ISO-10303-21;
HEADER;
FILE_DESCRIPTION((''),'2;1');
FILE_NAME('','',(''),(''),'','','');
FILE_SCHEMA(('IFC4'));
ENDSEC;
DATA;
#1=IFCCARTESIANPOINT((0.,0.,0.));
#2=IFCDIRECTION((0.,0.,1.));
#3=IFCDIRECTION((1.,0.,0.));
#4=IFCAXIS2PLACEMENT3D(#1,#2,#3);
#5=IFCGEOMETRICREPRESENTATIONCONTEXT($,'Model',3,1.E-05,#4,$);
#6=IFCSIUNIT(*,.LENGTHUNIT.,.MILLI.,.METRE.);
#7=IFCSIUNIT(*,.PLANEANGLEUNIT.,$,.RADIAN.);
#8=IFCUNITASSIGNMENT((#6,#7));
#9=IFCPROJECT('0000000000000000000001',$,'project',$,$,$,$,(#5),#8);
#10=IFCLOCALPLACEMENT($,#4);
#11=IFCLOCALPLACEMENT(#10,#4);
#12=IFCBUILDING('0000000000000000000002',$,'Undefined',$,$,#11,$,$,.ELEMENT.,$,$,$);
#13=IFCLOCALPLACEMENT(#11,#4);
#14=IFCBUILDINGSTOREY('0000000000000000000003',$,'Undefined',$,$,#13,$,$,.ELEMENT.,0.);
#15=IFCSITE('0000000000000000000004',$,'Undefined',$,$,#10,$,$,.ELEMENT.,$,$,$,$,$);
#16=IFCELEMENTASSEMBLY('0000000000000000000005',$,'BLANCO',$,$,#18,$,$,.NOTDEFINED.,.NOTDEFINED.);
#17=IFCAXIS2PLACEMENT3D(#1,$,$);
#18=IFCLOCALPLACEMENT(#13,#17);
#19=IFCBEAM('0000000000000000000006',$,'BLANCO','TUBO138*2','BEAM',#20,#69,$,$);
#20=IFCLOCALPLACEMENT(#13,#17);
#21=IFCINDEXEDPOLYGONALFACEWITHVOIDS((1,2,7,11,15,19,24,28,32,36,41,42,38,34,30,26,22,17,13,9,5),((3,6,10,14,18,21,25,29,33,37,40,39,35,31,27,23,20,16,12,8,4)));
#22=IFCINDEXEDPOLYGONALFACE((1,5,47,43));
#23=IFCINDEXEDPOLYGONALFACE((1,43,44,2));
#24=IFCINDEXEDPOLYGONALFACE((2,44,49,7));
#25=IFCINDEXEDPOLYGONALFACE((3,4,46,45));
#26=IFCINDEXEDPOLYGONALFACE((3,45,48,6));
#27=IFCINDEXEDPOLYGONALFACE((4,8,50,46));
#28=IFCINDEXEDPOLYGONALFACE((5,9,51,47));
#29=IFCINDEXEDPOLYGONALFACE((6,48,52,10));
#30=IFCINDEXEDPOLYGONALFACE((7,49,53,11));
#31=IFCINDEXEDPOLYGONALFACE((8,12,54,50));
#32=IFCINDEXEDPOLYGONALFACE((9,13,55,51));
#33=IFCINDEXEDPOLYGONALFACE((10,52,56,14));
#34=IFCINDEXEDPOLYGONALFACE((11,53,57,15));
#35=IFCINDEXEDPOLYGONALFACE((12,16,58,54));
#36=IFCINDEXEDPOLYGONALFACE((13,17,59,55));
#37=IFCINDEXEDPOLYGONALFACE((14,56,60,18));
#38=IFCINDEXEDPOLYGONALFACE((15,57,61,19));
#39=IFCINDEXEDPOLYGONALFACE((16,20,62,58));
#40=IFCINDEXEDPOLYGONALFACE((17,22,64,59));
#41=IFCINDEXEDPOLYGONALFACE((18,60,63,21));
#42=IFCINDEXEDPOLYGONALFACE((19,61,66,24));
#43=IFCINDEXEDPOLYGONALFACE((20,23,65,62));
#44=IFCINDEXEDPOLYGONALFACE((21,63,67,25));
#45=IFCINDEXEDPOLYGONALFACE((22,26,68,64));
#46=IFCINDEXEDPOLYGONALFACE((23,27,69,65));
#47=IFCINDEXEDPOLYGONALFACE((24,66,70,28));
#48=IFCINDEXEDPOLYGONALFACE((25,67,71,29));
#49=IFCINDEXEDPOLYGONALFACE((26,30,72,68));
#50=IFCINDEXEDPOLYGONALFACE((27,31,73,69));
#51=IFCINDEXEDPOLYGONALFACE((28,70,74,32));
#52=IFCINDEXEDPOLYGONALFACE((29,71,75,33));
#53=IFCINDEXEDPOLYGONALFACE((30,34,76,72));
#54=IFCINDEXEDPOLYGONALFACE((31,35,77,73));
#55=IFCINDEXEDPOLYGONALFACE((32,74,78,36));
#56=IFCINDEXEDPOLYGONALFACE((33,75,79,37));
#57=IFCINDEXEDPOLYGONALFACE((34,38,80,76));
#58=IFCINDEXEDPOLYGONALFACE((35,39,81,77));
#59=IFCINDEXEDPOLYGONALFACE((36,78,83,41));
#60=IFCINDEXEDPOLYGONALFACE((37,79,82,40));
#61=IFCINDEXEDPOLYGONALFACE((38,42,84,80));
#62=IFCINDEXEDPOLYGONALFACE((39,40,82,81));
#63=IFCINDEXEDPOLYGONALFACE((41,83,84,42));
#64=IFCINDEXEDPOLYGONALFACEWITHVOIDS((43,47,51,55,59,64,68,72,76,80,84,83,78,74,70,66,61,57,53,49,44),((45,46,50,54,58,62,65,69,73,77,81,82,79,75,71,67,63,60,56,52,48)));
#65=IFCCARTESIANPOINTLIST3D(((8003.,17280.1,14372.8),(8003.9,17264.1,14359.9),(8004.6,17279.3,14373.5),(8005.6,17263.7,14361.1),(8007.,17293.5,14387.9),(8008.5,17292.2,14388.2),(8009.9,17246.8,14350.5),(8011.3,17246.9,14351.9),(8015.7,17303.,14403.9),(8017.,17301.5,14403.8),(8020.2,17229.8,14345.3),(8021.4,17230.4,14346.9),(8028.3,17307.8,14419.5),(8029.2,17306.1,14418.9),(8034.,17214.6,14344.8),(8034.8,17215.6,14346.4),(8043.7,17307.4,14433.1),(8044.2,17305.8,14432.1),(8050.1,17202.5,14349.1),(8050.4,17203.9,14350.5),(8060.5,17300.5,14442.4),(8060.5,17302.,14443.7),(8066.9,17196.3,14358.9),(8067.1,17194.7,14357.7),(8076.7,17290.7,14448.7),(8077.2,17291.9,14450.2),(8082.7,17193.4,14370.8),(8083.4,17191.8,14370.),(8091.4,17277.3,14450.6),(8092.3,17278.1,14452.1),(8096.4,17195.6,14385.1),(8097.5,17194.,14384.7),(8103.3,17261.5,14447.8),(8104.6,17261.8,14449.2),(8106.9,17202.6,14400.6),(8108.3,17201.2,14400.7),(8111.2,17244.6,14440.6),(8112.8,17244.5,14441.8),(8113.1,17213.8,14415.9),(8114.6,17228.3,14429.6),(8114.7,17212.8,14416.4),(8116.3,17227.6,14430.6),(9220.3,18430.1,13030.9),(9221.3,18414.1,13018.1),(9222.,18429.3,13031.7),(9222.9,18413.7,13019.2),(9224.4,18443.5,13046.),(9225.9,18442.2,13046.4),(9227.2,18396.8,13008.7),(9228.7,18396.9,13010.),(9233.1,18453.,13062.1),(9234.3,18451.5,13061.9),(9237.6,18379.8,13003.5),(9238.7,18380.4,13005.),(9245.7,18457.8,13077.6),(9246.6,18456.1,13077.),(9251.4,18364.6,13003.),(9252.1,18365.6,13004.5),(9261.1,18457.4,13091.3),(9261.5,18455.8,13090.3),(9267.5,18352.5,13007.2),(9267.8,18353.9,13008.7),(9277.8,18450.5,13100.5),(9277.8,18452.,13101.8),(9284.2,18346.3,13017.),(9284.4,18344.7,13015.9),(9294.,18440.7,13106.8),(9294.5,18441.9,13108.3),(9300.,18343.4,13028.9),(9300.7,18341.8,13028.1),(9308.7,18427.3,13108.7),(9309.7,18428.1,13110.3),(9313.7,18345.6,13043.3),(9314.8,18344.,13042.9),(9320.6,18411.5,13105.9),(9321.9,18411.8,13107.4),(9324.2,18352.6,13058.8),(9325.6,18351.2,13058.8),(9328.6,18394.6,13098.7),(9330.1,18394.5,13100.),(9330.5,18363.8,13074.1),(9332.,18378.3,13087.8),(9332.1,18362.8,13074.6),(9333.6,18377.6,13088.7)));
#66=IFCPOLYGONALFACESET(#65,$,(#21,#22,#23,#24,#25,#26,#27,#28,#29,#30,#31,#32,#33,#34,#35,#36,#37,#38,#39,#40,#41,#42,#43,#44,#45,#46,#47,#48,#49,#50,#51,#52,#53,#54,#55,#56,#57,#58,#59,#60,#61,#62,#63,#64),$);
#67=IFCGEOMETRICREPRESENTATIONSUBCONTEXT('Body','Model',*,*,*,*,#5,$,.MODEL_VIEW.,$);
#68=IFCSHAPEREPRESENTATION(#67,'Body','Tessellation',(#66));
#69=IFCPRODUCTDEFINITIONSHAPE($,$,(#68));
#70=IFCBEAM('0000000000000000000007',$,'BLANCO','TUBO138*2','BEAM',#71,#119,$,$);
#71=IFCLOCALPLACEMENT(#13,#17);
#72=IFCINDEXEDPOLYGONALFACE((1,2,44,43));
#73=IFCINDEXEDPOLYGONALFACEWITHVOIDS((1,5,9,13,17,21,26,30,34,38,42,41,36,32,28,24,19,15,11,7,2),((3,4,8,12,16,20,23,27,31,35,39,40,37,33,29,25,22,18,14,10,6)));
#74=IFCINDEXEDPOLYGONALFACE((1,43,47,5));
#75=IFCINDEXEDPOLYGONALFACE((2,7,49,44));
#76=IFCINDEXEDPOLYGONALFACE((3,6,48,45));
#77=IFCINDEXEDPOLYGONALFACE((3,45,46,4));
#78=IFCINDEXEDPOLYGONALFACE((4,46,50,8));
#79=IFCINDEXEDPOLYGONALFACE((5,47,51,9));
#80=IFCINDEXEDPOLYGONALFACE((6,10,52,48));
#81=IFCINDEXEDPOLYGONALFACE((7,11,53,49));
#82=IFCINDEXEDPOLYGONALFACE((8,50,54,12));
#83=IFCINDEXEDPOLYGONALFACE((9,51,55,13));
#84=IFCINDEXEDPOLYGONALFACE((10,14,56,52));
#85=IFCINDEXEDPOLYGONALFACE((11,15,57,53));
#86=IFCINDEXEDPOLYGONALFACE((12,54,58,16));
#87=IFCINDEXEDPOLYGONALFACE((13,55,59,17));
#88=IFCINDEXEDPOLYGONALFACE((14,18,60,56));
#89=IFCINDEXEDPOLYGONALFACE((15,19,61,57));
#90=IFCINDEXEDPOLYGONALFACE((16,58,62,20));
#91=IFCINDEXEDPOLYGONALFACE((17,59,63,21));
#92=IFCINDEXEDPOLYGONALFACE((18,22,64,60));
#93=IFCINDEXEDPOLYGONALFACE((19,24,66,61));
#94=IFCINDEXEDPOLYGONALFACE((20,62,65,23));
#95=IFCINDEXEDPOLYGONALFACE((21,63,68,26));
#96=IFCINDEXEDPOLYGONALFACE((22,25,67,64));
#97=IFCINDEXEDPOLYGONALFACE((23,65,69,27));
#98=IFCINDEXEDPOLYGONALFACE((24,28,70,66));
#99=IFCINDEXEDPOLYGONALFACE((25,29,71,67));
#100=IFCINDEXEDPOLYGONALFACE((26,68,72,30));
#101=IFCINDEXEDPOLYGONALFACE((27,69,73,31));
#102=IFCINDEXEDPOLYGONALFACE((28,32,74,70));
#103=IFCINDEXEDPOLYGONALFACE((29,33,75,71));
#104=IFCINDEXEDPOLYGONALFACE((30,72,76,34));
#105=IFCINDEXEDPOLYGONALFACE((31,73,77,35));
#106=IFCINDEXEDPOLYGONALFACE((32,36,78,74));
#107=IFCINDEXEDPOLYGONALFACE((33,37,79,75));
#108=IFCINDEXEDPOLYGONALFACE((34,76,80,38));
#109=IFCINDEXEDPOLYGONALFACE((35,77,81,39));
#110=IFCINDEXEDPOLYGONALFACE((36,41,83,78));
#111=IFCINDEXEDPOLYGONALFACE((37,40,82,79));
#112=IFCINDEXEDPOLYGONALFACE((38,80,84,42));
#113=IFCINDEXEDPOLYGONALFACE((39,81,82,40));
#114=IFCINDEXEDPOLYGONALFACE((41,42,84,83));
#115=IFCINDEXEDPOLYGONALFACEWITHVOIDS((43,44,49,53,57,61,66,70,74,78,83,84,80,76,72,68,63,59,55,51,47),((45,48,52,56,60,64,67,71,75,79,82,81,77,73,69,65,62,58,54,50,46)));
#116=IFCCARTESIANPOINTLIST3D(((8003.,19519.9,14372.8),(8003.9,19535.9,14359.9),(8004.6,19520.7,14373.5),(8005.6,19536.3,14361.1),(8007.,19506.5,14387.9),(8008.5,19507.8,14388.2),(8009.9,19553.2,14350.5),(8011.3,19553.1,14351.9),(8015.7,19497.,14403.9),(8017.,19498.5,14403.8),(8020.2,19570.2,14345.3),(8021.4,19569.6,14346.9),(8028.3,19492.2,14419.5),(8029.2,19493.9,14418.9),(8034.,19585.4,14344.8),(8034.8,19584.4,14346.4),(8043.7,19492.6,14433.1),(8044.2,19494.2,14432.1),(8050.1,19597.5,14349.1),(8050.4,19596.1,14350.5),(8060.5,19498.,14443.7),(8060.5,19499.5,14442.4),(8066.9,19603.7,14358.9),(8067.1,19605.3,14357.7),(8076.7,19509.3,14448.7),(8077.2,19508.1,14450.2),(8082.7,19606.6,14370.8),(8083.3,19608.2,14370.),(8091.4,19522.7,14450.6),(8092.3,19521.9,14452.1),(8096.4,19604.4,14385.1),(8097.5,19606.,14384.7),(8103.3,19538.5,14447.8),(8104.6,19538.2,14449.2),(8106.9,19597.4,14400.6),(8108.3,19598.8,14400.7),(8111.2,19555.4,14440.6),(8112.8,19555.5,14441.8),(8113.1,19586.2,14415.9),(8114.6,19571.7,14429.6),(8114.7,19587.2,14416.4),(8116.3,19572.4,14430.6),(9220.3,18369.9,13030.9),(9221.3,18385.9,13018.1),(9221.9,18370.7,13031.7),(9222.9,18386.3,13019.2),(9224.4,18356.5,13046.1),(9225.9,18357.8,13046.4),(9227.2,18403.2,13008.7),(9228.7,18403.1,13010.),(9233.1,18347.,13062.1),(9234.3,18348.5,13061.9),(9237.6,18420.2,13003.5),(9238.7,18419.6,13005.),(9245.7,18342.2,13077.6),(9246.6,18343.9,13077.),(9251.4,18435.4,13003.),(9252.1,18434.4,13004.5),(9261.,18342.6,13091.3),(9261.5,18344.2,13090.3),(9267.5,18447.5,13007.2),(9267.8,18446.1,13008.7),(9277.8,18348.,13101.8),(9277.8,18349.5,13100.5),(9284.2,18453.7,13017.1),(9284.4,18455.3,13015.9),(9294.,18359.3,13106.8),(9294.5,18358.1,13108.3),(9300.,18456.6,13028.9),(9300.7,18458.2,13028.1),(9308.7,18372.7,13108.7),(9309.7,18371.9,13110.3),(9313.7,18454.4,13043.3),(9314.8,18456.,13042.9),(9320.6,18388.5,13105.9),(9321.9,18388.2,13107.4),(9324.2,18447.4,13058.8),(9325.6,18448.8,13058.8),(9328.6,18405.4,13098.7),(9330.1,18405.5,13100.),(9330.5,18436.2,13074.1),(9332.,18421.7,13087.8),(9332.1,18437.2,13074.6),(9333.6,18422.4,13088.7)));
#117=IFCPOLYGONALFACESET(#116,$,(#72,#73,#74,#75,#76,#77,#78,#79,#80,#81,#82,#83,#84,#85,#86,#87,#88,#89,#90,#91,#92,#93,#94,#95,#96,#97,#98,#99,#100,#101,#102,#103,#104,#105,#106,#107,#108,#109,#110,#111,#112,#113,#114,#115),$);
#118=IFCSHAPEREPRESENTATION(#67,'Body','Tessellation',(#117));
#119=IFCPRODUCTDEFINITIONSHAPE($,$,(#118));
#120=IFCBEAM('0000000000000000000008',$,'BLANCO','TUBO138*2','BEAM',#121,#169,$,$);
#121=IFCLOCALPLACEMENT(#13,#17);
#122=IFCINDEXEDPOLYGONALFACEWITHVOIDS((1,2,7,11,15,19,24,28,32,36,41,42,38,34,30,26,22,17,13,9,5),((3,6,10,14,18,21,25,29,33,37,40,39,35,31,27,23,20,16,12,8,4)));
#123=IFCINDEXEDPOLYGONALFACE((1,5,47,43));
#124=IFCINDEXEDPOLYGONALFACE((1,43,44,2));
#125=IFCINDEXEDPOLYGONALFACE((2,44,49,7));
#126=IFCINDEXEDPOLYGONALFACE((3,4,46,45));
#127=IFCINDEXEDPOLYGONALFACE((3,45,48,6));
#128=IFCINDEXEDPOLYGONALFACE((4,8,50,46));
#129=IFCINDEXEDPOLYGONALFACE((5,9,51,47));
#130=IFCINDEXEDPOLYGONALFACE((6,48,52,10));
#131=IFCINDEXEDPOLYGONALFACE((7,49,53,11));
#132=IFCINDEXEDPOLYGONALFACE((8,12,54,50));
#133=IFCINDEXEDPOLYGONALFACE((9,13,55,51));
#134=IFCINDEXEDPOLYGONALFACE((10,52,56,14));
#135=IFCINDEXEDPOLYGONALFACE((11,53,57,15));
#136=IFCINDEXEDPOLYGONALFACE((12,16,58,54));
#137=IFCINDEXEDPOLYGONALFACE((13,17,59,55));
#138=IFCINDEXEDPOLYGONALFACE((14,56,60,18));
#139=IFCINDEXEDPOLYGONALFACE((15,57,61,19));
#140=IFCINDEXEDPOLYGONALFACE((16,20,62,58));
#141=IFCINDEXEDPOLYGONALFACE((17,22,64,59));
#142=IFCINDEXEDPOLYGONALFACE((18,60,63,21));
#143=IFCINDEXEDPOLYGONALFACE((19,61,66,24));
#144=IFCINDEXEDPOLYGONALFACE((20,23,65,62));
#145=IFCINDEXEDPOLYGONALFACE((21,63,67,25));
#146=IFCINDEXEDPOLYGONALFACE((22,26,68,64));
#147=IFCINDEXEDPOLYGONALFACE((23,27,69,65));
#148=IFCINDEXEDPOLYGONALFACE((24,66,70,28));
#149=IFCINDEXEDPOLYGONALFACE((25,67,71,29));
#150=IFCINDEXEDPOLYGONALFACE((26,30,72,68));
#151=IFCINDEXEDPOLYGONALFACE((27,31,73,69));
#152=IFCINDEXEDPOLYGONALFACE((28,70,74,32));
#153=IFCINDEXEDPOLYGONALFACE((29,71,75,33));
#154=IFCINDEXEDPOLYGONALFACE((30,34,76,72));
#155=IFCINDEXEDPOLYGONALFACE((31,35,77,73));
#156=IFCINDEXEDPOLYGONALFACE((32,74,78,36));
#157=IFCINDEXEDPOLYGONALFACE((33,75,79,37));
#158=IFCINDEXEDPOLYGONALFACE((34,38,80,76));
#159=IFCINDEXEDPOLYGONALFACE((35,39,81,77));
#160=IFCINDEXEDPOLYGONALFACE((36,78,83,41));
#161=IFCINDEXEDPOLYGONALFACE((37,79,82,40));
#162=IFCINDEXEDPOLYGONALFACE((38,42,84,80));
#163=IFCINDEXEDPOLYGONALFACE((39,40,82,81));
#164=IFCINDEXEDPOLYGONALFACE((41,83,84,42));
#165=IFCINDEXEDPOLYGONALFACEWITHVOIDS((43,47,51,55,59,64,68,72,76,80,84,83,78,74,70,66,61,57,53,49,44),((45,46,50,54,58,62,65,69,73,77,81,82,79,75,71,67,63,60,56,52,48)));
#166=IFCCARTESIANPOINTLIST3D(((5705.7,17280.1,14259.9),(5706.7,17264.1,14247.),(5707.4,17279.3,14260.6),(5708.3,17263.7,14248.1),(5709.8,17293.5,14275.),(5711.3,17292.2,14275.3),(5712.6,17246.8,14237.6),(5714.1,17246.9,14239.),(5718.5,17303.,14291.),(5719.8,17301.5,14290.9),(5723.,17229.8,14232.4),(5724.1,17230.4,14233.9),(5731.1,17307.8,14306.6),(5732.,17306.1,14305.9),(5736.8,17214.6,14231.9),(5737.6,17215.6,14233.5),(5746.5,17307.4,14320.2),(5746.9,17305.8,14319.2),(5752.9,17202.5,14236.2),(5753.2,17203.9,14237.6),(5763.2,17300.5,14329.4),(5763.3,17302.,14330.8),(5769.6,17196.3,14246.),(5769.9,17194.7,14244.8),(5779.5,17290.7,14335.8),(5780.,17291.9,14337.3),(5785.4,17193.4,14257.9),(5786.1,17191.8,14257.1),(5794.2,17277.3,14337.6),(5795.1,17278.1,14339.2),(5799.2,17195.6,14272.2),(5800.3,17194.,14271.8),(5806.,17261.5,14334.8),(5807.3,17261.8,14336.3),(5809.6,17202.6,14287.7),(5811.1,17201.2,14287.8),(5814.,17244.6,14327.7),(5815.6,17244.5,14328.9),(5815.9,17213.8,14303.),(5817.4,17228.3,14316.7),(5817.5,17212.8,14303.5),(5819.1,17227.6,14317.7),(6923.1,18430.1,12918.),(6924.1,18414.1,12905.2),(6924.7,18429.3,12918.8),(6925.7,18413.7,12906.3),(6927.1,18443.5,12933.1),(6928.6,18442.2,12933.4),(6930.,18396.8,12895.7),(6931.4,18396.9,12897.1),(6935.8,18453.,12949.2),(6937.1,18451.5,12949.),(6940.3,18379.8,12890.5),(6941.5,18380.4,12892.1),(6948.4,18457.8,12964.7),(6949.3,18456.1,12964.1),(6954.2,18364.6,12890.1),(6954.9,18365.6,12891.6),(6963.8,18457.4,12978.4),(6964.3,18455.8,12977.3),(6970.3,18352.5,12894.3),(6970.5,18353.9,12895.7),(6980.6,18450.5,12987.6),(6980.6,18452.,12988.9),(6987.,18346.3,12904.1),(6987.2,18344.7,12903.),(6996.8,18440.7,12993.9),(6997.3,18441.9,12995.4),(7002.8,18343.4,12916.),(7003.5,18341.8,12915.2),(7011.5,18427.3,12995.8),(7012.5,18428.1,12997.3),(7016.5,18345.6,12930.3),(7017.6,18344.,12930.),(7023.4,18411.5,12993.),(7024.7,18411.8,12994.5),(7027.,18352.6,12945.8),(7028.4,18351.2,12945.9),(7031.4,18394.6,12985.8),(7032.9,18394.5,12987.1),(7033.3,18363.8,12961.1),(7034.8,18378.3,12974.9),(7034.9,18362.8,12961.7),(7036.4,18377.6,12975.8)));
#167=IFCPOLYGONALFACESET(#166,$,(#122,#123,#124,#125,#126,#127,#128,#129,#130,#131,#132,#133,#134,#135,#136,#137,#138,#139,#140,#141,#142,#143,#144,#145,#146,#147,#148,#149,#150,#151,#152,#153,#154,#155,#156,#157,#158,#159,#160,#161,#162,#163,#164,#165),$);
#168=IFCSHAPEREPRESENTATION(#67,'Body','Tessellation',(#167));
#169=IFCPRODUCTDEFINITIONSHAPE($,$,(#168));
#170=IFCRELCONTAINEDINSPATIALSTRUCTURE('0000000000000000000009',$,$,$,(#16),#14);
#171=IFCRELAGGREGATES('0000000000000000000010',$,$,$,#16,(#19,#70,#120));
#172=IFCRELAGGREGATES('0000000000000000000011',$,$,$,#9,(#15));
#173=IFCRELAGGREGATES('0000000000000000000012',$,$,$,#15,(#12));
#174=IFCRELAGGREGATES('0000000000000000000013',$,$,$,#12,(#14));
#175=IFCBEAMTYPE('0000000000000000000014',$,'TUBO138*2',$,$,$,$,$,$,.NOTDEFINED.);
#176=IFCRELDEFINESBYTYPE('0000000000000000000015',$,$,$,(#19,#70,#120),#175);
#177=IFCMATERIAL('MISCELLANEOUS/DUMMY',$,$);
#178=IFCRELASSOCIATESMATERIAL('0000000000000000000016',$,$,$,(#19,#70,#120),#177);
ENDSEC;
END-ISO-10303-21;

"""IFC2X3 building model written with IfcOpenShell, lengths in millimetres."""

from ifc_helpers import new_model, si_unit, frame, origin_with_axes, origin_2d_with_axis, place, context, subcontext, project, spatial, hollow_circle, extrude, material, type_object, element, aggregate, save


model = new_model("IFC2X3")

# Units and contexts
model_context = context("Model", 3, precision=1e-05, world=origin_with_axes())
body_context = subcontext(model_context, "Body", "Model", "MODEL_VIEW")
ifc_project = project(units=[si_unit("LENGTHUNIT", "METRE", prefix="MILLI"), si_unit("PLANEANGLEUNIT", "RADIAN")], contexts=[model_context])

# Site, building, storey
site_placement = place(None, origin_with_axes())
site = spatial("IfcSite", under=ifc_project, at=site_placement, Name="Undefined", CompositionType="ELEMENT")
building_placement = place(site_placement, origin_with_axes())
building = spatial("IfcBuilding", under=site, at=building_placement, Name="Undefined", CompositionType="ELEMENT")
storey_placement = place(building_placement, origin_with_axes())
storey = spatial("IfcBuildingStorey", under=building, at=storey_placement, Name="Undefined", CompositionType="ELEMENT", Elevation=0.0)

# Element assembly, beams
assembly_placement = place(storey_placement, origin_with_axes())
assembly = element("IfcElementAssembly", 1, at=assembly_placement, inside=storey, Name="BLANCO", AssemblyPlace="NOTDEFINED", PredefinedType="NOTDEFINED")
ifc_material = material(Name="MISCELLANEOUS/DUMMY")
beam_type = type_object("IfcBeamType", Name="TUBO138*2", PredefinedType="NOTDEFINED")
beam_1_placement = place(assembly_placement, frame((9276.9, 18400.0, 13056.4), z_axis=(-0.423552, -0.461316, -0.77961), x_axis=(-0.567282, -0.535899, 0.625303)))
beam_1 = element("IfcBeam", 2, at=beam_1_placement, type_object=beam_type, material=ifc_material, Name="BLANCO", Description="TUBO138*2", ObjectType="BEAM", context=body_context, shape_type="SweptSolid", body=[
    extrude(hollow_circle(Radius=69.0, WallThickness=2.0, at=origin_2d_with_axis()), frame((2145.9, 0.0, 0.0), z_axis=(-1.0, 0.0, 0.0), x_axis=(0.0, -1.0, 0.0)), (0.0, 0.0, 1.0), 2145.9),
])
beam_2_placement = place(assembly_placement, frame((8059.5, 19550.0, 14398.3), z_axis=(-0.423552, 0.461316, -0.77961), x_axis=(0.567282, -0.535899, -0.625303)))
beam_2 = element("IfcBeam", 3, at=beam_2_placement, type_object=beam_type, material=ifc_material, Name="BLANCO", Description="TUBO138*2", ObjectType="BEAM", context=body_context, shape_type="SweptSolid", body=[
    extrude(hollow_circle(Radius=69.0, WallThickness=2.0, at=origin_2d_with_axis()), frame((2145.9, 0.0, 0.0), z_axis=(-1.0, 0.0, 0.0), x_axis=(0.0, -1.0, 0.0)), (0.0, 0.0, 1.0), 2145.9),
])
beam_3_placement = place(assembly_placement, frame((6979.7, 18400.0, 12943.5), z_axis=(-0.423552, -0.461316, -0.77961), x_axis=(-0.567282, -0.535899, 0.625303)))
beam_3 = element("IfcBeam", 4, at=beam_3_placement, type_object=beam_type, material=ifc_material, Name="BLANCO", Description="TUBO138*2", ObjectType="BEAM", context=body_context, shape_type="SweptSolid", body=[
    extrude(hollow_circle(Radius=69.0, WallThickness=2.0, at=origin_2d_with_axis()), frame((2145.9, 0.0, 0.0), z_axis=(-1.0, 0.0, 0.0), x_axis=(0.0, -1.0, 0.0)), (0.0, 0.0, 1.0), 2145.9),
])
aggregate(assembly, [beam_1, beam_2, beam_3])

save(model, "model.ifc")
